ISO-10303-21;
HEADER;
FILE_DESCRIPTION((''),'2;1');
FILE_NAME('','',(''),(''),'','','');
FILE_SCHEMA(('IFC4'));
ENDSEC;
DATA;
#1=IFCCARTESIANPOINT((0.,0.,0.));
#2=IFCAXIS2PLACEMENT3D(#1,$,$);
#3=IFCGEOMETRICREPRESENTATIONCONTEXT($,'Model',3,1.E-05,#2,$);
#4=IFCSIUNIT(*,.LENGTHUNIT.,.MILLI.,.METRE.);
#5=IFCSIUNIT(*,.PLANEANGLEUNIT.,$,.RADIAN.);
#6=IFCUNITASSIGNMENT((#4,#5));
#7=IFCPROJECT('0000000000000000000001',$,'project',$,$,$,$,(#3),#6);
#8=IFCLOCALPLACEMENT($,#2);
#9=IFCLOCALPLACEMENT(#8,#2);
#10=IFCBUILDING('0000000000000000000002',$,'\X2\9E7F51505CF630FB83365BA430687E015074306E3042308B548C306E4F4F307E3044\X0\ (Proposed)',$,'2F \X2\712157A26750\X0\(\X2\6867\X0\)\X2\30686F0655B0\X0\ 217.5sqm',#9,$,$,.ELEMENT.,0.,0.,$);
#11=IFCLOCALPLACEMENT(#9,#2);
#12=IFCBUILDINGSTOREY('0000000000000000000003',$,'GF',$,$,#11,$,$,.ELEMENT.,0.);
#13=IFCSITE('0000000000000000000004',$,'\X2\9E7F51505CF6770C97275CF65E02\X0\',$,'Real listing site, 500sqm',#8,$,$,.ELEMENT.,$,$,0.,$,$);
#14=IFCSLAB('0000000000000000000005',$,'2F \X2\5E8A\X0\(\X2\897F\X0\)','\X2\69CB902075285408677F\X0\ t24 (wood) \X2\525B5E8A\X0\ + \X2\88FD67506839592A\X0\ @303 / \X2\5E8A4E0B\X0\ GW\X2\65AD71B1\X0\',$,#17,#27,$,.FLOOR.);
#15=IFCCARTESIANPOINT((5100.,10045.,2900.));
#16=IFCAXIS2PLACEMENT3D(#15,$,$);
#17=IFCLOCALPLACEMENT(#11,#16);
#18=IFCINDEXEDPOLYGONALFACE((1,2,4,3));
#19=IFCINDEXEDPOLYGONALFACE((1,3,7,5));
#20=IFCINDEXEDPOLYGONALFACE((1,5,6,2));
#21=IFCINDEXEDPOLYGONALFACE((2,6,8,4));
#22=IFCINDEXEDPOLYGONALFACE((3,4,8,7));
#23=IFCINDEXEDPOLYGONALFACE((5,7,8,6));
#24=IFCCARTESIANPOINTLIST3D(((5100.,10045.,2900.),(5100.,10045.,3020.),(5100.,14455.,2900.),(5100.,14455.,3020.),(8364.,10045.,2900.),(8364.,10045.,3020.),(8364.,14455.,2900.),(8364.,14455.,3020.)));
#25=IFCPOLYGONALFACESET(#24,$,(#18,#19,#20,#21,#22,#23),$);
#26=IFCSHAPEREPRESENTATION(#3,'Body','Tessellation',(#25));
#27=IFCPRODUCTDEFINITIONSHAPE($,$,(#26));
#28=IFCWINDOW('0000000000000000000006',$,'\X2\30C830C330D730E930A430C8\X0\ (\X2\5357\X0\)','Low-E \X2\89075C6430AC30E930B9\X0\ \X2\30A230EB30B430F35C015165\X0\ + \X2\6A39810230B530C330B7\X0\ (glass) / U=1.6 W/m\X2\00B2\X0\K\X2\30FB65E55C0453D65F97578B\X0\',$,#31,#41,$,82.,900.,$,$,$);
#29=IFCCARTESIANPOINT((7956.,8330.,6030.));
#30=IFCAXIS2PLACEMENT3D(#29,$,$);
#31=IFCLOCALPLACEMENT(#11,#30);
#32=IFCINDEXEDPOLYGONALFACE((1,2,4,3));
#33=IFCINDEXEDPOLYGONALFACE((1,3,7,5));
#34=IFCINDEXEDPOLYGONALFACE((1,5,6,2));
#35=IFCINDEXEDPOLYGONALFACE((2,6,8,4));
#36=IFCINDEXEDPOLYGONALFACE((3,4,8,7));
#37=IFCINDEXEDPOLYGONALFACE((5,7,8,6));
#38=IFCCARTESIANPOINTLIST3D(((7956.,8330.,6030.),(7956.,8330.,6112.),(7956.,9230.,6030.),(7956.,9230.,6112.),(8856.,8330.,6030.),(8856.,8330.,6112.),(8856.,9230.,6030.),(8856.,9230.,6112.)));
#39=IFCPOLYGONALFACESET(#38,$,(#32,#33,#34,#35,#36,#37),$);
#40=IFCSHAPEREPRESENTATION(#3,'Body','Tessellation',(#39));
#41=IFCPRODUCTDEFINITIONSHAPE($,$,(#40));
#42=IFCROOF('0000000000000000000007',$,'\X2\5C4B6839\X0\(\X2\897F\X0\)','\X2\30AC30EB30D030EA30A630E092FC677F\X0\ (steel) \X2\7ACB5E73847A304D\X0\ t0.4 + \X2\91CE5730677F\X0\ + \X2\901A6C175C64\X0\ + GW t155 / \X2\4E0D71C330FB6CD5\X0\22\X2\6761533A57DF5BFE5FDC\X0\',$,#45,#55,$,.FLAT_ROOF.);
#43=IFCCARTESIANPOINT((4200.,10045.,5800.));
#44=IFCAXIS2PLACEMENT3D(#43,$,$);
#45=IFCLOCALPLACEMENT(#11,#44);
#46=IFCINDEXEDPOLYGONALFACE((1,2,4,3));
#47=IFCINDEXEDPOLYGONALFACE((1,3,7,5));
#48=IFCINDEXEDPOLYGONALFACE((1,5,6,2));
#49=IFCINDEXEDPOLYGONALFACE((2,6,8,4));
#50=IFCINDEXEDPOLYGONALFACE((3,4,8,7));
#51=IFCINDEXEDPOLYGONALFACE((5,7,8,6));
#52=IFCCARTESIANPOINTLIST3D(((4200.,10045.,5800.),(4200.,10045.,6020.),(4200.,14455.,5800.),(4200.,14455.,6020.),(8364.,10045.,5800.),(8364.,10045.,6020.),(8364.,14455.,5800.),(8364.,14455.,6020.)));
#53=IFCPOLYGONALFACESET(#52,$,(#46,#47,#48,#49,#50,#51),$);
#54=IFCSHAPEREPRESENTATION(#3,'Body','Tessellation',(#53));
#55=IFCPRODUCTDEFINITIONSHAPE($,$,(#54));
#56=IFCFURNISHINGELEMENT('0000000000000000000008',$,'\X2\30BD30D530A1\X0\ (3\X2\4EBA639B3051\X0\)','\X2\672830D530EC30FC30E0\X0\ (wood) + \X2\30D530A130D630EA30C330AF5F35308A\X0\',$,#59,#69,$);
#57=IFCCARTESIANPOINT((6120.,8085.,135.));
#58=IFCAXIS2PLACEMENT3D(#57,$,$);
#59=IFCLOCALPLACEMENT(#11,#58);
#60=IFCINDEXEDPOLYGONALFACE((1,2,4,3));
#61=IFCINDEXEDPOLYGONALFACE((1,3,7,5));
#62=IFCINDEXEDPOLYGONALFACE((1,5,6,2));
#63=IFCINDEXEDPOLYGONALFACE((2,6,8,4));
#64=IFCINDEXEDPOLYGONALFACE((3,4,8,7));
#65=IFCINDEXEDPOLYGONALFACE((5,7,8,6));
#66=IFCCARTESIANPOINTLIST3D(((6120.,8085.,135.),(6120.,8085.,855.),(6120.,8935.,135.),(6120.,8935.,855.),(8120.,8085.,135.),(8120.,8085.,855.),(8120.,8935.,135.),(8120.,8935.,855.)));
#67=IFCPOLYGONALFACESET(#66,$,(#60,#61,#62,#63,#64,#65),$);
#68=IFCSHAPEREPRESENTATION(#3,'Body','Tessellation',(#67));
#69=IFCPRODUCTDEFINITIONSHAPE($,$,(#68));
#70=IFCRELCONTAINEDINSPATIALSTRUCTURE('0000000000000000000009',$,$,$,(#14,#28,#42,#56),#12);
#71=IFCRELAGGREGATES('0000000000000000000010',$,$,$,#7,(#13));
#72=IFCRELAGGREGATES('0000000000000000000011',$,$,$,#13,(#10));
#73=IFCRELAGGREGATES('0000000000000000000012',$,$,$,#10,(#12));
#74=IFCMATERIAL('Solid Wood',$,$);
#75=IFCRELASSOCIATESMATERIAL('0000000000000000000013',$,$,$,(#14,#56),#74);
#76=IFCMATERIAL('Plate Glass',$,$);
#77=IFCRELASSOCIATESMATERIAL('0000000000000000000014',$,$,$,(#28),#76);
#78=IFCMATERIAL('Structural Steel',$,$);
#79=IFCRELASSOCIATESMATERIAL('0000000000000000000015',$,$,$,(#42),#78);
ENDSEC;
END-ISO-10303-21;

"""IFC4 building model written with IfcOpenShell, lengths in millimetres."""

from ifc_helpers import new_model, si_unit, frame, frame_2d, origin, place, context, project, spatial, rectangle, extrude, material, element, save


model = new_model("IFC4")

# Units and contexts
model_context = context("Model", 3, precision=1e-05, world=origin())
ifc_project = project(units=[si_unit("LENGTHUNIT", "METRE", prefix="MILLI"), si_unit("PLANEANGLEUNIT", "RADIAN")], contexts=[model_context])

# Site, building, storey
site_placement = place(None, origin())
site = spatial("IfcSite", under=ifc_project, at=site_placement, Name="鹿児島県霧島市", ObjectType="Real listing site, 500sqm", CompositionType="ELEMENT", RefElevation=0.0)
building_placement = place(site_placement, origin())
building = spatial("IfcBuilding", under=site, at=building_placement, Name="鹿児島・茶室と縁側のある和の住まい (Proposed)", ObjectType="2F 無垢材(桧)と漆喰 217.5sqm", CompositionType="ELEMENT", ElevationOfRefHeight=0.0, ElevationOfTerrain=0.0)
storey_placement = place(building_placement, origin())
storey = spatial("IfcBuildingStorey", under=building, at=storey_placement, Name="GF", CompositionType="ELEMENT", Elevation=0.0)

# Shared definitions
ifc_material_1 = material(Name="Solid Wood")

# Slab
slab_1_placement = place(storey_placement, frame((5100.0, 10045.0, 2900.0)))
element("IfcSlab", 1, at=slab_1_placement, inside=storey, material=ifc_material_1, Name="2F 床(西)", Description="構造用合板 t24 (wood) 剛床 + 製材根太 @303 / 床下 GW断熱", PredefinedType="FLOOR", context=model_context, shape_type="SweptSolid", body=[
    extrude(rectangle(XDim=3264.0, YDim=4410.0, at=frame_2d((1632.0, 2205.0))), frame((5100.0, 10045.0, 2900.0)), (0.0, 0.0, 1.0), 120.0),
])

# Window
ifc_material_2 = material(Name="Plate Glass")
window_placement = place(storey_placement, frame((7956.0, 8330.0, 6030.0)))
element("IfcWindow", 2, at=window_placement, inside=storey, material=ifc_material_2, Name="トップライト (南)", Description="Low-E 複層ガラス アルゴン封入 + 樹脂サッシ (glass) / U=1.6 W/m²K・日射取得型", OverallHeight=82.0, OverallWidth=900.0, context=model_context, shape_type="SweptSolid", body=[
    extrude(rectangle(XDim=900.0, YDim=900.0, at=frame_2d((450.0, 450.0))), frame((7956.0, 8330.0, 6030.0)), (0.0, 0.0, 1.0), 82.0),
])

# Roof
ifc_material_3 = material(Name="Structural Steel")
for number, where, name in (
    (3, (4200.0, 10045.0, 5800.0), "屋根(西)"),
):
    element("IfcRoof", number, at=place(storey_placement, frame(where)), inside=storey, material=ifc_material_3, Name=name, Description="ガルバリウム鋼板 (steel) 立平葺き t0.4 + 野地板 + 通気層 + GW t155 / 不燃・法22条区域対応", PredefinedType="FLAT_ROOF", context=model_context, shape_type="SweptSolid", body=[
        extrude(rectangle(XDim=4164.0, YDim=4410.0, at=frame_2d((2082.0, 2205.0))), frame((4200.0, 10045.0, 5800.0)), (0.0, 0.0, 1.0), 220.0),
    ])

# Furnishing element
furnishing_placement = place(storey_placement, frame((6120.0, 8085.0, 135.0)))
element("IfcFurnishingElement", 4, at=furnishing_placement, inside=storey, material=ifc_material_1, Name="ソファ (3人掛け)", Description="木フレーム (wood) + ファブリック張り", context=model_context, shape_type="SweptSolid", body=[
    extrude(rectangle(XDim=2000.0, YDim=850.0, at=frame_2d((1000.0, 425.0))), frame((6120.0, 8085.0, 135.0)), (0.0, 0.0, 1.0), 720.0),
])

save(model, "model.ifc")
